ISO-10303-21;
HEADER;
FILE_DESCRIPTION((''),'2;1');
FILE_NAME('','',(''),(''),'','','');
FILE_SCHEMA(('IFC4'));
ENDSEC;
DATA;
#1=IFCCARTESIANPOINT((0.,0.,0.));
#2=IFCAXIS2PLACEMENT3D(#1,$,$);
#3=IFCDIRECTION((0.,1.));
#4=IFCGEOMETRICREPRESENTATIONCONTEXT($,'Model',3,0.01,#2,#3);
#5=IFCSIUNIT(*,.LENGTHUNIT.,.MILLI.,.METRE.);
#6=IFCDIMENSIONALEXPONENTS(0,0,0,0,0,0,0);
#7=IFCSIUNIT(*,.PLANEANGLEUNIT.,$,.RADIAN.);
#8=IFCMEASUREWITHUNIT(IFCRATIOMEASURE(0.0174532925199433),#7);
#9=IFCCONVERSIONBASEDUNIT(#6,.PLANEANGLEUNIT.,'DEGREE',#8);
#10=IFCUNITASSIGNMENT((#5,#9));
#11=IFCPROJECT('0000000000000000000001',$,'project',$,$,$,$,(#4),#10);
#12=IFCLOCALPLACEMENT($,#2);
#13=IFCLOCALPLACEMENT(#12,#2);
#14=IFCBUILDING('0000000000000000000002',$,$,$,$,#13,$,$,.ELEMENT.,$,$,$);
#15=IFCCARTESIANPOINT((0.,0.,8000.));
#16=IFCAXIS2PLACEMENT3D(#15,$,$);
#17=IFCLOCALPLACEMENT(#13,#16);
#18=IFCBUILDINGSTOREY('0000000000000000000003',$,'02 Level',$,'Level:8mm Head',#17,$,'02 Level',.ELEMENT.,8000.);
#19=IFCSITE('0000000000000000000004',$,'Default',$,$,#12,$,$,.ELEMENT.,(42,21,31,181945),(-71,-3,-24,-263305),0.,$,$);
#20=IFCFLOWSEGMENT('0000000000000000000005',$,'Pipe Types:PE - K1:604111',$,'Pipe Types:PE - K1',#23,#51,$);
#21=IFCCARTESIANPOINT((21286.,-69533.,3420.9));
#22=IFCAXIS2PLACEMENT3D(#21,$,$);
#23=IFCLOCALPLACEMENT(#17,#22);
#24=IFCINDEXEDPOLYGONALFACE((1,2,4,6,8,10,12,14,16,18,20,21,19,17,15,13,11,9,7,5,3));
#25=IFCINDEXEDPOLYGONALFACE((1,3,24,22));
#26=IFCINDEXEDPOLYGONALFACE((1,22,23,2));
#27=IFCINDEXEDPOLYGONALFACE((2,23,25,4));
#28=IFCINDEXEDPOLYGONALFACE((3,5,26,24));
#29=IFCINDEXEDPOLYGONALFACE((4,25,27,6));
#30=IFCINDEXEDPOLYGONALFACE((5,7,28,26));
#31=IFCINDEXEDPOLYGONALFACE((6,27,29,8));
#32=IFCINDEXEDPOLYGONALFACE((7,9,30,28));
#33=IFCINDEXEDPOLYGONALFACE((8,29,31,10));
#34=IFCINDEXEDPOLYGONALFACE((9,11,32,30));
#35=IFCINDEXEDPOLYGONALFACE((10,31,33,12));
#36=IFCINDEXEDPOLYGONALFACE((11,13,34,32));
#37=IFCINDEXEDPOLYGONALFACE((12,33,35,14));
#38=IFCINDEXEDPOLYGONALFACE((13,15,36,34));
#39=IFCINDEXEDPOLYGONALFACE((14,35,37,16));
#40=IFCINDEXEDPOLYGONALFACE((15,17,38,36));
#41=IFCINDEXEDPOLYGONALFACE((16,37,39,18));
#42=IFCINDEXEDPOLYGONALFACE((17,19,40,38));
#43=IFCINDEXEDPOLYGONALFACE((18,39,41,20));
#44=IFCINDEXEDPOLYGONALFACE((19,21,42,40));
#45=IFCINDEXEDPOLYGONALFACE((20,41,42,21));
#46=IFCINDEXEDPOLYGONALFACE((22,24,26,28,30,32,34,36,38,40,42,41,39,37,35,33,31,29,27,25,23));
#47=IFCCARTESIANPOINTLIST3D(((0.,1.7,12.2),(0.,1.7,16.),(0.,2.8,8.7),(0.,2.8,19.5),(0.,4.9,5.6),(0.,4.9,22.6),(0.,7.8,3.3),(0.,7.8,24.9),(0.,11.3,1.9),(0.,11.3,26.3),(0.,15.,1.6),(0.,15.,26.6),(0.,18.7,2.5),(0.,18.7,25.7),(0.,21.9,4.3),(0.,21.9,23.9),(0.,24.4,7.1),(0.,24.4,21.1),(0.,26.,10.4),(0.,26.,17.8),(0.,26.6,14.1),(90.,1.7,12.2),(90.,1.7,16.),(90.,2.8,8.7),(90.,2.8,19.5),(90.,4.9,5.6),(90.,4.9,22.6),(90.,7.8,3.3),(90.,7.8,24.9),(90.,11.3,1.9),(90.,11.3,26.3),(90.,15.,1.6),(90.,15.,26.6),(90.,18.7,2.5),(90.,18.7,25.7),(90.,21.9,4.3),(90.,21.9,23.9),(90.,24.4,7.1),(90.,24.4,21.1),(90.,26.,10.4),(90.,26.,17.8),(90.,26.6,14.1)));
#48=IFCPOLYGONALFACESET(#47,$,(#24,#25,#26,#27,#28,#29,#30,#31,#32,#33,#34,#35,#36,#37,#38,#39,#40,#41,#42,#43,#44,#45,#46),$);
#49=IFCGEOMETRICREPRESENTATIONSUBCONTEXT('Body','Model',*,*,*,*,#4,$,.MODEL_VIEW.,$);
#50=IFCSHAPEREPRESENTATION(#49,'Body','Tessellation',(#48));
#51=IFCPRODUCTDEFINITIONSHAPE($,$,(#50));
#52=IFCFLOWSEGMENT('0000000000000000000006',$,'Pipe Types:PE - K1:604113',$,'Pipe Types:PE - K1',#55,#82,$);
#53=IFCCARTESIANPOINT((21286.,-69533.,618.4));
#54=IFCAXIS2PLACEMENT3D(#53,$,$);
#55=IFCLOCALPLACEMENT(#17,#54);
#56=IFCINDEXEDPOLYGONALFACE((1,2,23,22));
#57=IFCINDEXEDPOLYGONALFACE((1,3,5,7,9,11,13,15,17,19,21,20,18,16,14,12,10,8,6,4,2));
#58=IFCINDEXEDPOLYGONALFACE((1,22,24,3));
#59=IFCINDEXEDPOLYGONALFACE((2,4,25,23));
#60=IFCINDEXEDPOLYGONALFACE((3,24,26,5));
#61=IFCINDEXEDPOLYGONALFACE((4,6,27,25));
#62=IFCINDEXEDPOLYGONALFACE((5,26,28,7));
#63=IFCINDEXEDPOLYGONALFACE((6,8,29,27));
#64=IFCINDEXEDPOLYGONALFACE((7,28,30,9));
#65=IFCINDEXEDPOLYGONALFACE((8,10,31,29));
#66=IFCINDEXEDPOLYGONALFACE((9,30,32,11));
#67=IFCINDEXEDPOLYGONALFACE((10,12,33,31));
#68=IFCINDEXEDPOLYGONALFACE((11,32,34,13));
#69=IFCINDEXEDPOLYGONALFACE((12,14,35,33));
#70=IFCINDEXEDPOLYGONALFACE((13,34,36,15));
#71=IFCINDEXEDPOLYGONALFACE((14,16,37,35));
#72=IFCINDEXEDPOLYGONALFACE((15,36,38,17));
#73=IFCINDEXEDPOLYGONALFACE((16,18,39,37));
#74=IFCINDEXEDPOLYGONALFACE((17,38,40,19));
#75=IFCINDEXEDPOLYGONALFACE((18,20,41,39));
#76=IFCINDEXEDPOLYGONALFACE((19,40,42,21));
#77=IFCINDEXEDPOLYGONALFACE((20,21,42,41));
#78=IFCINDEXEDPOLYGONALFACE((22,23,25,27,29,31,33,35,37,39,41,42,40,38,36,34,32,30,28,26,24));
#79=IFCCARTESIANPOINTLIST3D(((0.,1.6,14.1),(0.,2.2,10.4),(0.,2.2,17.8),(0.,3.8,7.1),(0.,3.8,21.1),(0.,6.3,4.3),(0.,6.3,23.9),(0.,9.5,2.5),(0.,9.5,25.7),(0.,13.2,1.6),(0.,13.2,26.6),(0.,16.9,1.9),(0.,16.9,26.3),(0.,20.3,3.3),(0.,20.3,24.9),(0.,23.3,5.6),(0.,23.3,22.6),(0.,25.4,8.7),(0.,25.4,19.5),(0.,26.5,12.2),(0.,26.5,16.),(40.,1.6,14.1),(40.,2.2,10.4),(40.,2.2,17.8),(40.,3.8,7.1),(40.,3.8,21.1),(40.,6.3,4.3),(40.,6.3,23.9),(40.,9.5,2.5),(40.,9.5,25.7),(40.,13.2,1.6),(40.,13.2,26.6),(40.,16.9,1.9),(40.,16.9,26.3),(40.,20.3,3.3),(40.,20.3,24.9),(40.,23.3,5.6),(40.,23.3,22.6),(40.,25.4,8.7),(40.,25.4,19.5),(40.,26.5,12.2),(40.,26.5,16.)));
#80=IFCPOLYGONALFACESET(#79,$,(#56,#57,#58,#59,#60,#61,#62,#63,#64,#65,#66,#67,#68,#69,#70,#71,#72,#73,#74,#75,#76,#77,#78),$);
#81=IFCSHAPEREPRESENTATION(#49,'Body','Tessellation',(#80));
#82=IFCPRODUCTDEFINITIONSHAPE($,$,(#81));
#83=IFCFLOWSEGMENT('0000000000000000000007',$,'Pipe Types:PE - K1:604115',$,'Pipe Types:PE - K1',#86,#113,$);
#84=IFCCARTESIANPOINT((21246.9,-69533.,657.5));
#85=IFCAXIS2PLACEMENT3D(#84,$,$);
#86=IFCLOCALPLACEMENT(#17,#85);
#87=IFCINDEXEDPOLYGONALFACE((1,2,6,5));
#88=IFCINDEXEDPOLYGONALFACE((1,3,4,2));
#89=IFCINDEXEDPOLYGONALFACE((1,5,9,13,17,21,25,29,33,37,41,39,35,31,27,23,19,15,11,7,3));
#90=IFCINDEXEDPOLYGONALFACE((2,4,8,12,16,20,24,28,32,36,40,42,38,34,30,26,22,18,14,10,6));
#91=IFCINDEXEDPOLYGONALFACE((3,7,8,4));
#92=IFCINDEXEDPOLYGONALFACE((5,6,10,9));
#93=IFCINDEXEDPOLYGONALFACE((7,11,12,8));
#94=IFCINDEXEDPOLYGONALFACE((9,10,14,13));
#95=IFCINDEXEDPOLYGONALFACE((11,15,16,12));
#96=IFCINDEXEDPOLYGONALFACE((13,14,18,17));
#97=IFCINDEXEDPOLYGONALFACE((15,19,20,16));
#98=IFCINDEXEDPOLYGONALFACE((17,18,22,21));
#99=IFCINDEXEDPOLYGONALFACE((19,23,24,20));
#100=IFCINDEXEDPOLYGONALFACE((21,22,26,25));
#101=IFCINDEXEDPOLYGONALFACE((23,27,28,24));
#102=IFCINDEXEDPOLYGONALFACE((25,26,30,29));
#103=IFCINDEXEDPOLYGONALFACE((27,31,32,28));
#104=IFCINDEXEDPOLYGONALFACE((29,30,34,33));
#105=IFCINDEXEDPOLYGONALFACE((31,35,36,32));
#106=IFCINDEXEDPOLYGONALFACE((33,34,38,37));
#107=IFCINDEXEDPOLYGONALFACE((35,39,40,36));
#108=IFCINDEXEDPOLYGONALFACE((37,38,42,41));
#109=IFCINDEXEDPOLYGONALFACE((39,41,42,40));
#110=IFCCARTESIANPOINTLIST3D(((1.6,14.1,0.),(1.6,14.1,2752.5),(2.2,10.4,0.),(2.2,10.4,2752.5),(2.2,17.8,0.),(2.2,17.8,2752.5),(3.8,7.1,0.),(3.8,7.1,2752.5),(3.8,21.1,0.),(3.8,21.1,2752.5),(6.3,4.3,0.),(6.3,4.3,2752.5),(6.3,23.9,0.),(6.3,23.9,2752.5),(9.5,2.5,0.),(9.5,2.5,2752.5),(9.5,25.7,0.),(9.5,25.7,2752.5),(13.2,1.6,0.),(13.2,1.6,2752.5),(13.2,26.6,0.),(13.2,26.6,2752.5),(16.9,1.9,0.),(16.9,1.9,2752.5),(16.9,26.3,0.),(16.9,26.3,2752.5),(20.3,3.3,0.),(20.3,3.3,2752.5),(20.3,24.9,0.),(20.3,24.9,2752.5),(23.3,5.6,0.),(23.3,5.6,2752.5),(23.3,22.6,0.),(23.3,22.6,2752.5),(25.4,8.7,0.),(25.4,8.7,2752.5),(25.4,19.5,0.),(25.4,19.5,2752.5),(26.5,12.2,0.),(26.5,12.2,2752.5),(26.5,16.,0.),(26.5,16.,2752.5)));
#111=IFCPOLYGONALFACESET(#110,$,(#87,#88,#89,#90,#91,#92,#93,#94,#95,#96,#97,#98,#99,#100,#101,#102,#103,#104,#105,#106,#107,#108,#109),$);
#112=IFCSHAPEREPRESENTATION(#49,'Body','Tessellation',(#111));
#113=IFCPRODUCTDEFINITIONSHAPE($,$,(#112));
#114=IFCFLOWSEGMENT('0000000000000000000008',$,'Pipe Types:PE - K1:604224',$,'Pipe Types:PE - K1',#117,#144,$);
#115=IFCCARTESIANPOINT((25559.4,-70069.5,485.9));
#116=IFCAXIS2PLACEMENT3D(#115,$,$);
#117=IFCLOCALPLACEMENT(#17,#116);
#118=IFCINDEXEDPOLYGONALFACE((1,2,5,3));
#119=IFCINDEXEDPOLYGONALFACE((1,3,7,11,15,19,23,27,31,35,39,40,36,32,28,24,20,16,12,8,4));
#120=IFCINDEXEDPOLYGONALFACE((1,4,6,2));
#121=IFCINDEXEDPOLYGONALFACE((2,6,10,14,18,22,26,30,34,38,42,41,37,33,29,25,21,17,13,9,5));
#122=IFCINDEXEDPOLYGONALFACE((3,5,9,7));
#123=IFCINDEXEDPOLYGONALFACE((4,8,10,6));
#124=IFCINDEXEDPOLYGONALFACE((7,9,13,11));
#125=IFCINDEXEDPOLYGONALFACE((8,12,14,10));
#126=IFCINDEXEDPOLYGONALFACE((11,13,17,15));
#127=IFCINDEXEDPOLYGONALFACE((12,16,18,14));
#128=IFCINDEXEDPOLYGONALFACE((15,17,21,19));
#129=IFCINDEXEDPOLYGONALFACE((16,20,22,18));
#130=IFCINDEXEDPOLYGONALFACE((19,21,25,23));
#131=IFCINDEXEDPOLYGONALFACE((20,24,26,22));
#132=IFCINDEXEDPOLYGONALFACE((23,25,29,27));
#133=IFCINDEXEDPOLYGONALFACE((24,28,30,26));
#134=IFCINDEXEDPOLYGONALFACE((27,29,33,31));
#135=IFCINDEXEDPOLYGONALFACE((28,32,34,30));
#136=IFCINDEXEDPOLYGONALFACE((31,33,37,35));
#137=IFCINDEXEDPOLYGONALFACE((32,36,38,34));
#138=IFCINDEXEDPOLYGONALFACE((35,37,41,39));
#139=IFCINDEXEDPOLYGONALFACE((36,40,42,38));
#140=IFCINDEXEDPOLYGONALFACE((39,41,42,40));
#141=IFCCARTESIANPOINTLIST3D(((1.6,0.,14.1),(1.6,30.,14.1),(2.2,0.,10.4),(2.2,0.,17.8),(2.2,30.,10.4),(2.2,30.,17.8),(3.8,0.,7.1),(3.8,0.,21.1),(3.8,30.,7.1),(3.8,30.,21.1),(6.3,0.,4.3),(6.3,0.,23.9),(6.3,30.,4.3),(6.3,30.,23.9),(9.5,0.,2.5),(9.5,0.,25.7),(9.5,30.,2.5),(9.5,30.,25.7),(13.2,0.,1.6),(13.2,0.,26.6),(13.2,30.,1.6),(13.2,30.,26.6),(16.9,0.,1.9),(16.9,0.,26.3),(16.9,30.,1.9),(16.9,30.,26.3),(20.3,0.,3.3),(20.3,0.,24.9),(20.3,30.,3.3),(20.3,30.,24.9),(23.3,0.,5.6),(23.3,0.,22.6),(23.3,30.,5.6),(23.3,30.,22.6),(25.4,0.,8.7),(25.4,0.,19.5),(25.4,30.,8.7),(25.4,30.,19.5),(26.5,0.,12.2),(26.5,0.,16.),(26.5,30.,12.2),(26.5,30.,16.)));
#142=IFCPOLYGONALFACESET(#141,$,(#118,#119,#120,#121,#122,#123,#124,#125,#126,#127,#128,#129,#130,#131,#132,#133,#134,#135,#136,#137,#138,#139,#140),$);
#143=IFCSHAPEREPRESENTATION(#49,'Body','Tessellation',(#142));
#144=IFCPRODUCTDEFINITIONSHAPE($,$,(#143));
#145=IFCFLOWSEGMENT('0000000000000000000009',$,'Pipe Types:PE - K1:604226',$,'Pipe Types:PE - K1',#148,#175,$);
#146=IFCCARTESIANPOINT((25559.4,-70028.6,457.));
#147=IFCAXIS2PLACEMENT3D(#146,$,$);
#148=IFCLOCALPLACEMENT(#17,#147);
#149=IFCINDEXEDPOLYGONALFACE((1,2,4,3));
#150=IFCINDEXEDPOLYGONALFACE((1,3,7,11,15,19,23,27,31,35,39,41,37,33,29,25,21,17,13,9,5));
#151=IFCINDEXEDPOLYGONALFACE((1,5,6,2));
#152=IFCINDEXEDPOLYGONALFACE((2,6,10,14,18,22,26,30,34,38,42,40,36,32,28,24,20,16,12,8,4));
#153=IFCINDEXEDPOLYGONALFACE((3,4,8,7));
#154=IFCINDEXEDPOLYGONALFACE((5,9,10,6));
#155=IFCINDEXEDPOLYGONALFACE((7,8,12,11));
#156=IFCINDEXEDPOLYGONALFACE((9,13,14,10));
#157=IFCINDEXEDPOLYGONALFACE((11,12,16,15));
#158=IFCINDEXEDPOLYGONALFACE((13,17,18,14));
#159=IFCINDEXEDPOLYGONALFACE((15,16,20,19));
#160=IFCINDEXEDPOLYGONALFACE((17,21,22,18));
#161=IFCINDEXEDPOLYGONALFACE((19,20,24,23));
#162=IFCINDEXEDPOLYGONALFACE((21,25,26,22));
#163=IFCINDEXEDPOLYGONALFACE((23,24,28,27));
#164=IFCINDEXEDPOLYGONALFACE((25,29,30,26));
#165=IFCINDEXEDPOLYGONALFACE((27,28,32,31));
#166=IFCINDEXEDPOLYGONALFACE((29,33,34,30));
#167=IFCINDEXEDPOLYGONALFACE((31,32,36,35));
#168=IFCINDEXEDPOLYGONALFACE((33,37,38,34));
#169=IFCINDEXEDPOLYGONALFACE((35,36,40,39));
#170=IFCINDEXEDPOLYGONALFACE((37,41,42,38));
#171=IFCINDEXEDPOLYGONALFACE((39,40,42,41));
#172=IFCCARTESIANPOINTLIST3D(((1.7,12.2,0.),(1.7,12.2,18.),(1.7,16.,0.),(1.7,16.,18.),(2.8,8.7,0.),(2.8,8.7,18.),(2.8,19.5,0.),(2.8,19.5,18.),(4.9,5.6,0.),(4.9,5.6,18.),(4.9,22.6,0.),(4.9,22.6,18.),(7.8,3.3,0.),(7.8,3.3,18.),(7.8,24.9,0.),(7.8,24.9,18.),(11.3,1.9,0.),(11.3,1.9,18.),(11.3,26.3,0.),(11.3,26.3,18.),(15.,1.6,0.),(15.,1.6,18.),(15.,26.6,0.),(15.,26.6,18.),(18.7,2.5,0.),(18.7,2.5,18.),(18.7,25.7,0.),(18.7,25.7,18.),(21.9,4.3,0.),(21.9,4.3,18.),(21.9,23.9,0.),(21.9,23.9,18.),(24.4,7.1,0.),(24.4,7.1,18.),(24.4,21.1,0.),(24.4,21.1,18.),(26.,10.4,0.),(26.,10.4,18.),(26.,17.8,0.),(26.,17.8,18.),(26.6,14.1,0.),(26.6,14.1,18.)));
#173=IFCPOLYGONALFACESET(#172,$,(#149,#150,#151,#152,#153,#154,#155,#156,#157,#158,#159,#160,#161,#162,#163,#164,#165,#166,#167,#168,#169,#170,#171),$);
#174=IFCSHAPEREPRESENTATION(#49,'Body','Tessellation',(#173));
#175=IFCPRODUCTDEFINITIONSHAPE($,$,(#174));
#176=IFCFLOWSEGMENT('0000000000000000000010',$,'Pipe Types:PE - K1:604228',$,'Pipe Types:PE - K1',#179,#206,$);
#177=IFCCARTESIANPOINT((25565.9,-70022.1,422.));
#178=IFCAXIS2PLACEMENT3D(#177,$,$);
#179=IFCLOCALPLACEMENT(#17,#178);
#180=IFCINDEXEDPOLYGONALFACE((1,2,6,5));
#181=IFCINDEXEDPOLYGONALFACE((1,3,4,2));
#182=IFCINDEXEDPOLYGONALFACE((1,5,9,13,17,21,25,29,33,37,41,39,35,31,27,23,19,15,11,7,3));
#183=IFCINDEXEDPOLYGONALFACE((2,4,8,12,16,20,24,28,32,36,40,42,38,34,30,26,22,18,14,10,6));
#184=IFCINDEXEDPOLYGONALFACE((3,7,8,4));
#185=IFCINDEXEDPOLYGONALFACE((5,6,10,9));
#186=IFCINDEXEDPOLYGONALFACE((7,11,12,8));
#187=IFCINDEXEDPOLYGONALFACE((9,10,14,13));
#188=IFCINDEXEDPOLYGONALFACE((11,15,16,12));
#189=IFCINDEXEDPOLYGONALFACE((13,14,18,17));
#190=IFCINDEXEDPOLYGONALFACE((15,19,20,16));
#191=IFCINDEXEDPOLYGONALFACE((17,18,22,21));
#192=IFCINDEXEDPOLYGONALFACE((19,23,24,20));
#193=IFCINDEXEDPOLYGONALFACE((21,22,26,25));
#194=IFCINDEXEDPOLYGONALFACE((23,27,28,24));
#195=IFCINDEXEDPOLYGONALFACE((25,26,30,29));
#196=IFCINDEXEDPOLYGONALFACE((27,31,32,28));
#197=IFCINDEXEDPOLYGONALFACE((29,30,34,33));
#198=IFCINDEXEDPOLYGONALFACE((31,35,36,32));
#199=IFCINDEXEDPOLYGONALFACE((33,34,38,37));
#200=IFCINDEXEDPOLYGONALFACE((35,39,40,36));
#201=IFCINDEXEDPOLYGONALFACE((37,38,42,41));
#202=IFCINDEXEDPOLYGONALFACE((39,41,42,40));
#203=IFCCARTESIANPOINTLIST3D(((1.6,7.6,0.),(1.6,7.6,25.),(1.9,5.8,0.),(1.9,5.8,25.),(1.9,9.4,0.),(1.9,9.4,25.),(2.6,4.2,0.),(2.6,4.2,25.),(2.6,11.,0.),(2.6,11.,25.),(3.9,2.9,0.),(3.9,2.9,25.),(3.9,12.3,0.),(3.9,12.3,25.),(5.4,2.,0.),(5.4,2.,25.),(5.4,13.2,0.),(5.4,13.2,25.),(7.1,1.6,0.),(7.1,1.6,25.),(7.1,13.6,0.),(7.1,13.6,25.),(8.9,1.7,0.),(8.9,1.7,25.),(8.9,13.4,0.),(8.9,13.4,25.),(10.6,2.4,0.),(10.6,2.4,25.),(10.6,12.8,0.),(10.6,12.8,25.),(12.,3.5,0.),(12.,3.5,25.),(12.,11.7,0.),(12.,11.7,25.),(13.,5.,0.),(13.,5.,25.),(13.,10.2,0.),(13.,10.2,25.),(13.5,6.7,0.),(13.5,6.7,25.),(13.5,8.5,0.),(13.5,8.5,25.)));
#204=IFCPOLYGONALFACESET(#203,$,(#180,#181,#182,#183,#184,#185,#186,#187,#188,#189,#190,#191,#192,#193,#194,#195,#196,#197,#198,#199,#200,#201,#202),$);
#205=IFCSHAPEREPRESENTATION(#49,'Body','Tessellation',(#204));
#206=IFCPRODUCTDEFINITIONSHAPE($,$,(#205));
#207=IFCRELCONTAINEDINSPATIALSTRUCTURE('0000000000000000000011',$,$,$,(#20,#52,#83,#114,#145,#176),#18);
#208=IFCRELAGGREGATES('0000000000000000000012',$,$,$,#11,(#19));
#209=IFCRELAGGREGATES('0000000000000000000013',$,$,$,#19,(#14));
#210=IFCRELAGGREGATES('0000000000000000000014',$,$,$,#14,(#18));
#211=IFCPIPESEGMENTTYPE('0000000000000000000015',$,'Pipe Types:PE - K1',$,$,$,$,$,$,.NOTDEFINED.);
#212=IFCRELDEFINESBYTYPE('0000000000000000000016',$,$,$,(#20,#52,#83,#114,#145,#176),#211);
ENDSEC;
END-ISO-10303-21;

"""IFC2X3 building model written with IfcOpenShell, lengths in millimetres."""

from ifc_helpers import new_model, entity, si_unit, converted_unit, direction, frame, frame_2d, origin, origin_2d_with_axis, place, context, subcontext, project, spatial, circle, extrude, type_object, element, save


model = new_model("IFC2X3")

# Units and contexts
model_context = context("Model", 3, precision=0.01, world=origin(), true_north=direction((0.0, 1.0)))
body_context = subcontext(model_context, "Body", "Model", "MODEL_VIEW")
ifc_project = project(units=[si_unit("LENGTHUNIT", "METRE", prefix="MILLI"), converted_unit("PLANEANGLEUNIT", "DEGREE", entity("IfcRatioMeasure", 0.0174532925199433), si_unit("PLANEANGLEUNIT", "RADIAN"), dimensions=[0, 0, 0, 0, 0, 0, 0])], contexts=[model_context])

# Site, building, storey
site_placement = place(None, origin())
site = spatial("IfcSite", under=ifc_project, at=site_placement, Name="Default", CompositionType="ELEMENT", RefLatitude=(42, 21, 31, 181945), RefLongitude=(-71, -3, -24, -263305), RefElevation=0.0)
building_placement = place(site_placement, origin())
building = spatial("IfcBuilding", under=site, at=building_placement, CompositionType="ELEMENT")
storey_placement = place(building_placement, frame((0.0, 0.0, 8000.0)))
storey = spatial("IfcBuildingStorey", under=building, at=storey_placement, Name="02 Level", ObjectType="Level:8mm Head", LongName="02 Level", CompositionType="ELEMENT", Elevation=8000.0)

# Flow segments
pipe_segment_type = type_object("IfcPipeSegmentType", Name="Pipe Types:PE - K1", PredefinedType="NOTDEFINED")
flow_segment_1_placement = place(storey_placement, frame((21286.0, -69533.0, 3420.9)))
element("IfcFlowSegment", 1, at=flow_segment_1_placement, inside=storey, type_object=pipe_segment_type, Name="Pipe Types:PE - K1:604111", ObjectType="Pipe Types:PE - K1", context=body_context, shape_type="SweptSolid", body=[
    extrude(circle(Radius=12.5, at=origin_2d_with_axis()), frame((0.0, 14.1, 14.1), z_axis=(1.0, 0.0, 0.0), x_axis=(0.0, 1.0, 0.0)), (0.0, 0.0, 1.0), 90.0),
])
flow_segment_2_placement = place(storey_placement, frame((21286.0, -69533.0, 618.4)))
element("IfcFlowSegment", 2, at=flow_segment_2_placement, inside=storey, type_object=pipe_segment_type, Name="Pipe Types:PE - K1:604113", ObjectType="Pipe Types:PE - K1", context=body_context, shape_type="SweptSolid", body=[
    extrude(circle(Radius=12.5, at=frame_2d((0.0, 0.0), x_axis=(1.0, 0.0))), frame((0.0, 14.1, 14.1), z_axis=(1.0, 0.0, 0.0), x_axis=(0.0, -1.0, 0.0)), (0.0, 0.0, 1.0), 40.0),
])
flow_segment_3_placement = place(storey_placement, frame((21246.9, -69533.0, 657.5)))
element("IfcFlowSegment", 3, at=flow_segment_3_placement, inside=storey, type_object=pipe_segment_type, Name="Pipe Types:PE - K1:604115", ObjectType="Pipe Types:PE - K1", context=body_context, shape_type="SweptSolid", body=[
    extrude(circle(Radius=12.5, at=frame_2d((0.0, 0.0), x_axis=(1.0, 0.0))), frame((14.1, 14.1, 0.0), z_axis=(0.0, 0.0, 1.0), x_axis=(-1.0, 0.0, 0.0)), (0.0, 0.0, 1.0), 2752.5),
])
flow_segment_4_placement = place(storey_placement, frame((25559.4, -70069.5, 485.9)))
element("IfcFlowSegment", 4, at=flow_segment_4_placement, inside=storey, type_object=pipe_segment_type, Name="Pipe Types:PE - K1:604224", ObjectType="Pipe Types:PE - K1", context=body_context, shape_type="SweptSolid", body=[
    extrude(circle(Radius=12.5, at=origin_2d_with_axis()), frame((14.1, 0.0, 14.1), z_axis=(0.0, 1.0, 0.0), x_axis=(-1.0, 0.0, 0.0)), (0.0, 0.0, 1.0), 30.0),
])
flow_segment_5_placement = place(storey_placement, frame((25559.4, -70028.6, 457.0)))
element("IfcFlowSegment", 5, at=flow_segment_5_placement, inside=storey, type_object=pipe_segment_type, Name="Pipe Types:PE - K1:604226", ObjectType="Pipe Types:PE - K1", context=body_context, shape_type="SweptSolid", body=[
    extrude(circle(Radius=12.5, at=origin_2d_with_axis()), frame((14.1, 14.1, 0.0)), (0.0, 0.0, 1.0), 18.0),
])
flow_segment_6_placement = place(storey_placement, frame((25565.9, -70022.1, 422.0)))
element("IfcFlowSegment", 6, at=flow_segment_6_placement, inside=storey, type_object=pipe_segment_type, Name="Pipe Types:PE - K1:604228", ObjectType="Pipe Types:PE - K1", context=body_context, shape_type="SweptSolid", body=[
    extrude(circle(Radius=6.0, at=origin_2d_with_axis()), frame((7.6, 7.6, 0.0), z_axis=(0.0, 0.0, 1.0), x_axis=(-1.0, 0.0, 0.0)), (0.0, 0.0, 1.0), 25.0),
])

save(model, "model.ifc")
